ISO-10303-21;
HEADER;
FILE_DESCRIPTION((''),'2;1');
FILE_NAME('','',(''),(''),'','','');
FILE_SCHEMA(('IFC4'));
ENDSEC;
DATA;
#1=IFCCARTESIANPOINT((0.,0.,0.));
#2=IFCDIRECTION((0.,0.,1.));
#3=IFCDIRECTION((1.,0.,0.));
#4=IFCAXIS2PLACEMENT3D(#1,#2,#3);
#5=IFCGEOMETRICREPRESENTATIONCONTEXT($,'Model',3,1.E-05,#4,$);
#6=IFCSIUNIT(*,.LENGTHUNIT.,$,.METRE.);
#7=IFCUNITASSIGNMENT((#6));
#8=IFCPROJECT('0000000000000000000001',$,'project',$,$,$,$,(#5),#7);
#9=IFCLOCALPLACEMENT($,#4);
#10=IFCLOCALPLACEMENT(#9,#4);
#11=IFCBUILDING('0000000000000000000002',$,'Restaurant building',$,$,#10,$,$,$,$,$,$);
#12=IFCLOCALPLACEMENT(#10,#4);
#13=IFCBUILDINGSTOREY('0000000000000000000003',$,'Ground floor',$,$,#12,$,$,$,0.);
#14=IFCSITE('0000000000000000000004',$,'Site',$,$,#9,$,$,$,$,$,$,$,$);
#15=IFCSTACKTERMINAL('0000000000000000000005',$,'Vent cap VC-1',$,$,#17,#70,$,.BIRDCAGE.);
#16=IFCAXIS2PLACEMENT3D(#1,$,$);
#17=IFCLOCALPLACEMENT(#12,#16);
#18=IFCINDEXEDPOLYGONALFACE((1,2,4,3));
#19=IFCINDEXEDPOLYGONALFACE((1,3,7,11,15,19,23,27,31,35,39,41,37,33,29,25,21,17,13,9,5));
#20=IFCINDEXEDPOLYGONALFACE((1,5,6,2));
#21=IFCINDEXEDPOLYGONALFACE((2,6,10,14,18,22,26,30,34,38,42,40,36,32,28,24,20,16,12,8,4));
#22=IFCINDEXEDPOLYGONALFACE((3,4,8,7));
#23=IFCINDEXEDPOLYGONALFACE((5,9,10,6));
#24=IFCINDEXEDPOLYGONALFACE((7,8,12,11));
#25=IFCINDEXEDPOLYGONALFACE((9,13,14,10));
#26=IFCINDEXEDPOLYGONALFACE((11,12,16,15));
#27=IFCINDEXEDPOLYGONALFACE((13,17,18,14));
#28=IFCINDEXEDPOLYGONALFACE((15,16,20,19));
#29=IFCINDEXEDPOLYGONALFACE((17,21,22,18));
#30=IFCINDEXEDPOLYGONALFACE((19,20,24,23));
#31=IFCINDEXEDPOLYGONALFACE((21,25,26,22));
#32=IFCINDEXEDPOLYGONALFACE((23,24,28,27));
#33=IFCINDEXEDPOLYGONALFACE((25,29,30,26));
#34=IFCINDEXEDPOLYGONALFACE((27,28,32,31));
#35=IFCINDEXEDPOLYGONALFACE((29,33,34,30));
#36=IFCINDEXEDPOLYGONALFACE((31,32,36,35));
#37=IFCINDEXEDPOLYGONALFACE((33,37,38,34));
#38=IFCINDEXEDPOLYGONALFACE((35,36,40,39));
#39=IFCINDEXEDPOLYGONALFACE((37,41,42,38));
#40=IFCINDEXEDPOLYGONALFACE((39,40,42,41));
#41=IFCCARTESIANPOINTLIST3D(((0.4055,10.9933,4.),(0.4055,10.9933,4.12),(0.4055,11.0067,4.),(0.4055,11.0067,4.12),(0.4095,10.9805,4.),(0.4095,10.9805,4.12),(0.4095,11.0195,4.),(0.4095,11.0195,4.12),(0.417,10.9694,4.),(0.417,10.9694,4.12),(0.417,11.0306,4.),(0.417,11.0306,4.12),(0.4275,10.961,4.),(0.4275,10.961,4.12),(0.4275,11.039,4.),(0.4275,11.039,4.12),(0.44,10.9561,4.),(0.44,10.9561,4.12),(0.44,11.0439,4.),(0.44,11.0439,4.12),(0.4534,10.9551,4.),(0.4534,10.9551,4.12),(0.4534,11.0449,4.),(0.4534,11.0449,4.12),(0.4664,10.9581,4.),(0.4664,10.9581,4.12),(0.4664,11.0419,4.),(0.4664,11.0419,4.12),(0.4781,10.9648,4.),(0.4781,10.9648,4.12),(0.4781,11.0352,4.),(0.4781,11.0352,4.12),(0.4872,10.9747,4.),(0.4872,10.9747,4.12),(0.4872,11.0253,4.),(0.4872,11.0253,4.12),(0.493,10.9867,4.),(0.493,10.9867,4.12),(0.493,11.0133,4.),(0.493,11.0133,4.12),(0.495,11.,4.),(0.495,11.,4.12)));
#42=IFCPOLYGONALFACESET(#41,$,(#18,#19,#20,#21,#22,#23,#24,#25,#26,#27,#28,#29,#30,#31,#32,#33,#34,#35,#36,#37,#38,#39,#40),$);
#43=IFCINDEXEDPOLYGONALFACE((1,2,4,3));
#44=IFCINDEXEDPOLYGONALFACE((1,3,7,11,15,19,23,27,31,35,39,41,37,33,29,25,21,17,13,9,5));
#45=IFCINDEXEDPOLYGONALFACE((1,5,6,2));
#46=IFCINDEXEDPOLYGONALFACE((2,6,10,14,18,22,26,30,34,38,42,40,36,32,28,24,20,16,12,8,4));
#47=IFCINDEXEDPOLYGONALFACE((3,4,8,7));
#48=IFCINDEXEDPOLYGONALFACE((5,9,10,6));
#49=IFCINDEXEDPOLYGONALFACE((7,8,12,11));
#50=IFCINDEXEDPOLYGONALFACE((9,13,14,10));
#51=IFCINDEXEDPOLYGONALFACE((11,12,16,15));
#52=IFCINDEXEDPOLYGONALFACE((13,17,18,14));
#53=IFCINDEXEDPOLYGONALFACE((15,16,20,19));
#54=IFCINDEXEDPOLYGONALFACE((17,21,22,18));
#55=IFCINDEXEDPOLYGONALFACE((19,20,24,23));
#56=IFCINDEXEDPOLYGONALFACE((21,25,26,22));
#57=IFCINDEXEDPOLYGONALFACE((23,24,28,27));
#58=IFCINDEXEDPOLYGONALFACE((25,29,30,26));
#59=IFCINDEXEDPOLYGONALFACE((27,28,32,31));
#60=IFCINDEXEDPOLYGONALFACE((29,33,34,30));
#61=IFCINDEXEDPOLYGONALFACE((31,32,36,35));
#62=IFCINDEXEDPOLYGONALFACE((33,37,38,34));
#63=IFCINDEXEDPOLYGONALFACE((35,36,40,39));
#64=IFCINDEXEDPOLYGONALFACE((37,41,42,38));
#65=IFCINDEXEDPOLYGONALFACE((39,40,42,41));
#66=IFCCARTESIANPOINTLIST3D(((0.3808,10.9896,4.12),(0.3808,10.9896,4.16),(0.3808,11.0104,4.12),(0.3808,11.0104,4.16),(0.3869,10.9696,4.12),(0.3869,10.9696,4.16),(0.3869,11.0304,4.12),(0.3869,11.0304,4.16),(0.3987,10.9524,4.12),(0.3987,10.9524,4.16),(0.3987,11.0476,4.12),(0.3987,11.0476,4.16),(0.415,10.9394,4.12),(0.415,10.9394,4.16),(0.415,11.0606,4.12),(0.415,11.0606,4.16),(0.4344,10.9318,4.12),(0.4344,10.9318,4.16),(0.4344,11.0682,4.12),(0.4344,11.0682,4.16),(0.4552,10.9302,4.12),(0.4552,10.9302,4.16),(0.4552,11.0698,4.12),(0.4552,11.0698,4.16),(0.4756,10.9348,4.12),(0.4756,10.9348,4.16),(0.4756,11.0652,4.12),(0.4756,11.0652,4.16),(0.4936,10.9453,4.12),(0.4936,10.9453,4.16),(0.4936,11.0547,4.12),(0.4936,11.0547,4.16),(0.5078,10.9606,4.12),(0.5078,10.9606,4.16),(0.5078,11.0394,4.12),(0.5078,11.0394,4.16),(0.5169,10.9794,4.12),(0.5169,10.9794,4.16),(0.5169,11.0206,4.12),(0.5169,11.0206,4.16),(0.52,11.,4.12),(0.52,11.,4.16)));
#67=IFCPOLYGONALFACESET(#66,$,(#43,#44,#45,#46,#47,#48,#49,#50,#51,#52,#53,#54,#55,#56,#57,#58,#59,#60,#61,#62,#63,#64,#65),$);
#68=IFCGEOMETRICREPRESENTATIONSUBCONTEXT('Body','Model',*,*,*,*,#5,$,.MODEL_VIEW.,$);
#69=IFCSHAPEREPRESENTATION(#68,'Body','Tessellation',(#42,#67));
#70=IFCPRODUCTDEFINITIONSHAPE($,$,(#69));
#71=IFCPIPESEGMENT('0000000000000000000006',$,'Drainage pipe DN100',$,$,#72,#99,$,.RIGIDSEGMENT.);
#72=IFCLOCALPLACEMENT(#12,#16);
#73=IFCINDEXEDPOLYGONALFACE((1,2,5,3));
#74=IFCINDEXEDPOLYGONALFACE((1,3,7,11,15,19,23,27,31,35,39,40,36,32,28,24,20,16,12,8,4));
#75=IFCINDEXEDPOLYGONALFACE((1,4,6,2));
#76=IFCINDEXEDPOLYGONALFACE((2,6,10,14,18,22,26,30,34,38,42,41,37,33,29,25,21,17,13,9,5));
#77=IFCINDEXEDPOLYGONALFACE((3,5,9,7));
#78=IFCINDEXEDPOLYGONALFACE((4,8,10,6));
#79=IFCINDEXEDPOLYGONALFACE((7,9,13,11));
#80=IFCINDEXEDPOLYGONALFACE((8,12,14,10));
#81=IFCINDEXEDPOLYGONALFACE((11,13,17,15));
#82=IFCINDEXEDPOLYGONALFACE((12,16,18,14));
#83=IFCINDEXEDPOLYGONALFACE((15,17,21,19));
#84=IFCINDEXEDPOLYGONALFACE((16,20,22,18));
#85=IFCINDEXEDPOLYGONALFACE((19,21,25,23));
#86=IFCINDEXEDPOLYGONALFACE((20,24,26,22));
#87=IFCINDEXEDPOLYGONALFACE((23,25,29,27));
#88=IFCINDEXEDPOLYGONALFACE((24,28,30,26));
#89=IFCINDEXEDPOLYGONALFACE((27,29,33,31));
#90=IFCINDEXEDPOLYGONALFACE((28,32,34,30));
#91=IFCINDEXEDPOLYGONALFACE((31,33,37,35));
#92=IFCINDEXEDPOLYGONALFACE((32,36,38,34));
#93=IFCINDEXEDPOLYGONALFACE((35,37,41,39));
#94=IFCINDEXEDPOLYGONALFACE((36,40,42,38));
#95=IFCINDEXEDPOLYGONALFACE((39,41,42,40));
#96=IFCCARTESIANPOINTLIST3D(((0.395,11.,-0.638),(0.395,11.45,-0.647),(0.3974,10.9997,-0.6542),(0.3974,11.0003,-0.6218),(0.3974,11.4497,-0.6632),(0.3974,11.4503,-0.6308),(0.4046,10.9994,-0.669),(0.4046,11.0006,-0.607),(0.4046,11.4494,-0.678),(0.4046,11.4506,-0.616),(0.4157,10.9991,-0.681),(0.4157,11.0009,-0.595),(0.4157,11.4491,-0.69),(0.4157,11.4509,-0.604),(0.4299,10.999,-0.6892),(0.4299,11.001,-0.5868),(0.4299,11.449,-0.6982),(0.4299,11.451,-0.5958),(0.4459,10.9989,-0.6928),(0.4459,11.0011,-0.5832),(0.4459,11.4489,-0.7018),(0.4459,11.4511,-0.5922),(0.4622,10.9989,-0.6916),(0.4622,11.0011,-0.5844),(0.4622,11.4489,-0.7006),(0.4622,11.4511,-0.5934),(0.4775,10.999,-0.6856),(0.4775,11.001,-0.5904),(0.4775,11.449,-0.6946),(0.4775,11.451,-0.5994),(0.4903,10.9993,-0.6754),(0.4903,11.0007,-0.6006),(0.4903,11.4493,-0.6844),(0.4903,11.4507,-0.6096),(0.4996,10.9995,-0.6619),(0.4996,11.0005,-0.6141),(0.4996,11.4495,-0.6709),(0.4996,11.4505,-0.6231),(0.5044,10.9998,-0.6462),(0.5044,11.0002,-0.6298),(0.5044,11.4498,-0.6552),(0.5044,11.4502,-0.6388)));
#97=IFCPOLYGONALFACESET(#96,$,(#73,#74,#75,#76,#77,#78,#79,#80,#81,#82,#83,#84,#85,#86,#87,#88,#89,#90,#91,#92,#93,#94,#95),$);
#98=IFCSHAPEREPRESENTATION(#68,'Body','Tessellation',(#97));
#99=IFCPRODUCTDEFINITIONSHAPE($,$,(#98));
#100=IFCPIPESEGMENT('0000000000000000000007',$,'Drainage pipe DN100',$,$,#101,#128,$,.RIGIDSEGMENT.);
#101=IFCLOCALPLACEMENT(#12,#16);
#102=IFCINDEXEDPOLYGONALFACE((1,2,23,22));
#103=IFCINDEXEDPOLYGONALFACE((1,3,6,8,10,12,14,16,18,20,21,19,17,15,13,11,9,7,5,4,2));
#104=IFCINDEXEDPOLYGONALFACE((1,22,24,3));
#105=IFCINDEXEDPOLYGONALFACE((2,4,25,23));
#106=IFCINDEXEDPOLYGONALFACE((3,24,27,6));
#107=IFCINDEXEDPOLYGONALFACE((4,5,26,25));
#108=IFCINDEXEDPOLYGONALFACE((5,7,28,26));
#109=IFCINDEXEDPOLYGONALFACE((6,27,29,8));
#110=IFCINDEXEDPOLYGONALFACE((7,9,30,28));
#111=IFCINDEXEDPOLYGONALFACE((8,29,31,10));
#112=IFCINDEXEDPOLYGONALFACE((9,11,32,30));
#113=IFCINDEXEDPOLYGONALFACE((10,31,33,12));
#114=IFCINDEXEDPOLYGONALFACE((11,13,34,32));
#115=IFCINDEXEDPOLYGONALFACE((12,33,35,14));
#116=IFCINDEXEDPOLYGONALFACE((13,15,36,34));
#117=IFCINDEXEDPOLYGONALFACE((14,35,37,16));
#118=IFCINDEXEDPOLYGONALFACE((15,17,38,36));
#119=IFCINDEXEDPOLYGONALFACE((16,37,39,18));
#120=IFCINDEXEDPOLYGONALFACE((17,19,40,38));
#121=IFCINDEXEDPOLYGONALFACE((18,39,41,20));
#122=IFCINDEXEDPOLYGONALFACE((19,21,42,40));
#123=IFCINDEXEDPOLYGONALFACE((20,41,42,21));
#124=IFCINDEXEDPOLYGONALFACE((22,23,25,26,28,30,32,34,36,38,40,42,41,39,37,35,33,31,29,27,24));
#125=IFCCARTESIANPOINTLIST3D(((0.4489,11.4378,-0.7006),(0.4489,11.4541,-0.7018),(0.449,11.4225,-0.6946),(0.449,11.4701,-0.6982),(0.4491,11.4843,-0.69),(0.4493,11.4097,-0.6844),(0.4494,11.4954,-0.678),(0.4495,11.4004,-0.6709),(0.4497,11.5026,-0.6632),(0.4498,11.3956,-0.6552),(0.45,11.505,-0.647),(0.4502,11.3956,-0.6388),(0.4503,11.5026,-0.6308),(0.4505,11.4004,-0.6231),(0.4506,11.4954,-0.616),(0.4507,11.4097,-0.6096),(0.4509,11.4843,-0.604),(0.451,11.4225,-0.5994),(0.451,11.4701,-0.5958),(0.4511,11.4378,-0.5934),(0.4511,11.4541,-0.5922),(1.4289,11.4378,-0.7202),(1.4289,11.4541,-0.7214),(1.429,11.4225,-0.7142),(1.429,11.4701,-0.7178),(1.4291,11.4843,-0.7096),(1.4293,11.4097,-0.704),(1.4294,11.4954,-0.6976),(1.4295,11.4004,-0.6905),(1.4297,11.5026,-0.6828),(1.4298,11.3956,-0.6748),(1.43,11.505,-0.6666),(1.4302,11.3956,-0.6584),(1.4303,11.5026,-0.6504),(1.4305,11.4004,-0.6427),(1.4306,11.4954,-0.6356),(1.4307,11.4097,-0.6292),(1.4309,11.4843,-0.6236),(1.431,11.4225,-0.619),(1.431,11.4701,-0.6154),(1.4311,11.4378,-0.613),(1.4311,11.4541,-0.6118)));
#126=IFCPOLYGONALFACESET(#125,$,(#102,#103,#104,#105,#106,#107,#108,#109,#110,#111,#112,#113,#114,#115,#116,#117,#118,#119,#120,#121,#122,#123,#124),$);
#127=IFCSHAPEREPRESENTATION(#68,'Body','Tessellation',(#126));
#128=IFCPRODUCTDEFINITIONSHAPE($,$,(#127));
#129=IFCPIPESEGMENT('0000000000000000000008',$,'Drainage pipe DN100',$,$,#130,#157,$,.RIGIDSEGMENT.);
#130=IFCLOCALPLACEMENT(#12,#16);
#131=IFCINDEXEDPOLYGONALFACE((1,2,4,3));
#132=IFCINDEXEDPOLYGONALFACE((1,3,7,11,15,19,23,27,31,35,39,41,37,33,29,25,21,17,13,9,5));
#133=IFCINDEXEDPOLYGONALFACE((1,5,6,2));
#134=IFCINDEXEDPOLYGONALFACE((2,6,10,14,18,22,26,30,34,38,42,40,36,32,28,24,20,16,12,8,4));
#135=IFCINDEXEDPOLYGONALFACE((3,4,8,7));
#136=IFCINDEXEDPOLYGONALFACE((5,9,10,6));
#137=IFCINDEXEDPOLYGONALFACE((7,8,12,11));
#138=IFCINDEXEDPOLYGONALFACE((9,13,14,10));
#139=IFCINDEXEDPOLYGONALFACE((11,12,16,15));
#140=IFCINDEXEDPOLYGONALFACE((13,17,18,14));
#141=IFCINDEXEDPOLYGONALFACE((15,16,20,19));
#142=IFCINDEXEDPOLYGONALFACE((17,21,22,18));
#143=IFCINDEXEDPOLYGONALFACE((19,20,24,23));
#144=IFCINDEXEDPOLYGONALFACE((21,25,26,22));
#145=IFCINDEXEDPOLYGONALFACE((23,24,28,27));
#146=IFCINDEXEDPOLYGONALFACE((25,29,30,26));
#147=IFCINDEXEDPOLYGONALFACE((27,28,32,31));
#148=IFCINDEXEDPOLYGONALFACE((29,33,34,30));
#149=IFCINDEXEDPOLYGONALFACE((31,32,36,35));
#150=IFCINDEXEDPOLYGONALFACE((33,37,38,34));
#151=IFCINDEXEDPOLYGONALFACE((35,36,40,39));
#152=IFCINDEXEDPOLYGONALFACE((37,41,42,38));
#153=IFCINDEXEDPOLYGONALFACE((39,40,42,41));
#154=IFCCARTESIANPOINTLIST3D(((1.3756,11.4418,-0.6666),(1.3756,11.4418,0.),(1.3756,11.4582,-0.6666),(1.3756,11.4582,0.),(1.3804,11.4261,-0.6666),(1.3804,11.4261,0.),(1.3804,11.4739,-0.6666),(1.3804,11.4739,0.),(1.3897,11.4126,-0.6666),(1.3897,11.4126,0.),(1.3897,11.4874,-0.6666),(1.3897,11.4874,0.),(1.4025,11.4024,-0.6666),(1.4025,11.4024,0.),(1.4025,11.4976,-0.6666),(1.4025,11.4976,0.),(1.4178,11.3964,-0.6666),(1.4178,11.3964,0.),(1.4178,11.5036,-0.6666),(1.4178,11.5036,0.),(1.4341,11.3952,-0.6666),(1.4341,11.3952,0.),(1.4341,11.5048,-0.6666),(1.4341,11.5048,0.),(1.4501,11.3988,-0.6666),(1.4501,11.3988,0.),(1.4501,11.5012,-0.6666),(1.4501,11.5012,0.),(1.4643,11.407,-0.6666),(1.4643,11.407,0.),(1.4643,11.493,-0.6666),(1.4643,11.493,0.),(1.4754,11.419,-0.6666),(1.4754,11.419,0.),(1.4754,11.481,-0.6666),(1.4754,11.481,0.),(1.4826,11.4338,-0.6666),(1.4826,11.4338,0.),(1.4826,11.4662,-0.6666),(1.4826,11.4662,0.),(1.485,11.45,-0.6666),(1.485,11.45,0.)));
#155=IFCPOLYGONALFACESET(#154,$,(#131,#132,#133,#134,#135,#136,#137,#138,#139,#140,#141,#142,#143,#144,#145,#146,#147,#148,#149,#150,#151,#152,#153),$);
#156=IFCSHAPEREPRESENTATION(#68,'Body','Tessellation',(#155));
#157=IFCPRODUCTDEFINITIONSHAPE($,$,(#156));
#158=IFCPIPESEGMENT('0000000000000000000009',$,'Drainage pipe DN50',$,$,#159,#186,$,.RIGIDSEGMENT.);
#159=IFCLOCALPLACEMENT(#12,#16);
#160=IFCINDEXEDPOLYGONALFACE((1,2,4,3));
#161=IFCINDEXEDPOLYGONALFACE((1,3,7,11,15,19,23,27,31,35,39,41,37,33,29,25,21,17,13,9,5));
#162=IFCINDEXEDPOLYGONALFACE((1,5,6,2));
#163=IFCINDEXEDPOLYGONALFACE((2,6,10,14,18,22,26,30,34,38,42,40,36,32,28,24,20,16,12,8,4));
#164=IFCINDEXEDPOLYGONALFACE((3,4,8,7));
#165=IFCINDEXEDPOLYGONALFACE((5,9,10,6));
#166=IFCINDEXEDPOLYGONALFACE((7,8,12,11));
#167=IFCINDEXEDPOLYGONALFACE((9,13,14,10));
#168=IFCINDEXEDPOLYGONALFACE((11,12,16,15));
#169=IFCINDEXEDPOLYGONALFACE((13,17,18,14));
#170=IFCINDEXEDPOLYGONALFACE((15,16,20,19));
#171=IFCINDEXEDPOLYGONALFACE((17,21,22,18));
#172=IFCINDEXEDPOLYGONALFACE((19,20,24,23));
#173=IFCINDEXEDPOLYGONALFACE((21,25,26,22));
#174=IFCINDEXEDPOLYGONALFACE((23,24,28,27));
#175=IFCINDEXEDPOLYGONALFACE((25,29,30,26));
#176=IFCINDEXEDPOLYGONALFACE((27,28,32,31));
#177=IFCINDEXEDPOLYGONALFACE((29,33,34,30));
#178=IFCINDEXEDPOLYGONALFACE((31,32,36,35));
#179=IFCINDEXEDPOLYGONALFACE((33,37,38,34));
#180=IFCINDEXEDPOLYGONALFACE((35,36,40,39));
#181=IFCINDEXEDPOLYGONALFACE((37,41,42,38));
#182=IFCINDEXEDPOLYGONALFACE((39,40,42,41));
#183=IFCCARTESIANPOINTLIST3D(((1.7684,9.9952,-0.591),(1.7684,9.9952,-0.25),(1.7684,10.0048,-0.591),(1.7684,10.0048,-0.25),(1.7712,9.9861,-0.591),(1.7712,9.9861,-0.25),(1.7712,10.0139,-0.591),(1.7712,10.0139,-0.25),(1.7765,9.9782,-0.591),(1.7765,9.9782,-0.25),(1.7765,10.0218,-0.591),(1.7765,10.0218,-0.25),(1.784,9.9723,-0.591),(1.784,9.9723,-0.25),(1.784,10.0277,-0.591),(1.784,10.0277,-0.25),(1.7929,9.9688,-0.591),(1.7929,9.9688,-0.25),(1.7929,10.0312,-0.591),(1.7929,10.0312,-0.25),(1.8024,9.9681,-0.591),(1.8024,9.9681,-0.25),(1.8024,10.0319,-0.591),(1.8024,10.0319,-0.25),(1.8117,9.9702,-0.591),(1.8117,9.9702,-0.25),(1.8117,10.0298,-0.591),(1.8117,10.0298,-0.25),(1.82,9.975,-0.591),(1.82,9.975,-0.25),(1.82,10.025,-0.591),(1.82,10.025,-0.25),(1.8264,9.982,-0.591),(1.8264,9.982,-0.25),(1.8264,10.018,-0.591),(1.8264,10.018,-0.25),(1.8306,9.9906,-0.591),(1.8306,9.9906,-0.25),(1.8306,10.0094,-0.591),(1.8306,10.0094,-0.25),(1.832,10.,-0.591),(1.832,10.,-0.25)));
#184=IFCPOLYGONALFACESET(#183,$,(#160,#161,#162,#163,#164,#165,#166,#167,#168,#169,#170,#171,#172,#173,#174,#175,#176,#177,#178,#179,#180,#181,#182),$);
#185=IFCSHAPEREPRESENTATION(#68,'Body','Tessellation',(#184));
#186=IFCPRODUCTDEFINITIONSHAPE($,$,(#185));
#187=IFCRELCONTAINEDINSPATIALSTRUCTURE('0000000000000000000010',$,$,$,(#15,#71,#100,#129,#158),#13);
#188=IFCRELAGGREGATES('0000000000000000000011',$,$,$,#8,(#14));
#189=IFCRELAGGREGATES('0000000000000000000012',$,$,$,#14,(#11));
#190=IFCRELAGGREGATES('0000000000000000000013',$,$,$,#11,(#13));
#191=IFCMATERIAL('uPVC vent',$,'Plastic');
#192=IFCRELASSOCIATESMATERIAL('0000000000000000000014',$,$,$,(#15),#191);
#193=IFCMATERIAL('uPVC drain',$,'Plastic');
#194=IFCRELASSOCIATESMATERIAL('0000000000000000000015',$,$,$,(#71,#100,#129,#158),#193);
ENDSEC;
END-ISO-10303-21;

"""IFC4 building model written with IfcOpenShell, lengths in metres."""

from ifc_helpers import new_model, si_unit, frame, origin_with_axes, origin_2d, place, context, subcontext, project, spatial, circle, extrude, material, element, save


model = new_model("IFC4")

# Units and contexts
model_context = context("Model", 3, precision=1e-05, world=origin_with_axes())
body_context = subcontext(model_context, "Body", "Model", "MODEL_VIEW")
ifc_project = project(units=[si_unit("LENGTHUNIT", "METRE")], contexts=[model_context])

# Site, building, storey
site_placement = place(None, origin_with_axes())
site = spatial("IfcSite", under=ifc_project, at=site_placement, Name="Site")
building_placement = place(site_placement, origin_with_axes())
building = spatial("IfcBuilding", under=site, at=building_placement, Name="Restaurant building")
storey_placement = place(building_placement, origin_with_axes())
storey = spatial("IfcBuildingStorey", under=building, at=storey_placement, Name="Ground floor", Elevation=0.0)

# Shared definitions
ifc_material_1 = material(Name="uPVC drain", Category="Plastic")

# Stack terminal
ifc_material_2 = material(Name="uPVC vent", Category="Plastic")
stack_terminal_1_placement = place(storey_placement, frame((0.45, 11.0, 0.0)))
element("IfcStackTerminal", 1, at=stack_terminal_1_placement, inside=storey, material=ifc_material_2, Name="Vent cap VC-1", PredefinedType="BIRDCAGE", context=body_context, shape_type="SweptSolid", body=[
    extrude(circle(Radius=0.045, at=origin_2d()), frame((0.0, 0.0, 4.0)), (0.0, 0.0, 1.0), 0.12),
    extrude(circle(Radius=0.07, at=origin_2d()), frame((0.0, 0.0, 4.12)), (0.0, 0.0, 1.0), 0.04),
])

# Pipe segments
pipe_segment_1_placement = place(storey_placement, frame((0.45, 11.0, -0.638)))
element("IfcPipeSegment", 2, at=pipe_segment_1_placement, inside=storey, material=ifc_material_1, Name="Drainage pipe DN100", PredefinedType="RIGIDSEGMENT", context=body_context, shape_type="SweptSolid", body=[
    extrude(circle(Radius=0.055, at=origin_2d()), frame((0.0, 0.0, 0.0), z_axis=(0.0, 0.9998, -0.019996), x_axis=(-1.0, 0.0, 0.0)), (0.0, 0.0, 1.0), 0.4501),
])
pipe_segment_2_placement = place(storey_placement, frame((0.45, 11.45, -0.647)))
element("IfcPipeSegment", 3, at=pipe_segment_2_placement, inside=storey, material=ifc_material_1, Name="Drainage pipe DN100", PredefinedType="RIGIDSEGMENT", context=body_context, shape_type="SweptSolid", body=[
    extrude(circle(Radius=0.055, at=origin_2d()), frame((0.0, 0.0, 0.0), z_axis=(0.9998, 0.0, -0.019996), x_axis=(0.0, 1.0, 0.0)), (0.0, 0.0, 1.0), 0.9802),
])
pipe_segment_3_placement = place(storey_placement, frame((1.43, 11.45, 0.0)))
element("IfcPipeSegment", 4, at=pipe_segment_3_placement, inside=storey, material=ifc_material_1, Name="Drainage pipe DN100", PredefinedType="RIGIDSEGMENT", context=body_context, shape_type="SweptSolid", body=[
    extrude(circle(Radius=0.055, at=origin_2d()), frame((0.0, 0.0, 0.0), z_axis=(0.0, 0.0, -1.0), x_axis=(1.0, 0.0, 0.0)), (0.0, 0.0, 1.0), 0.6666),
])
pipe_segment_4_placement = place(storey_placement, frame((1.8, 10.0, -0.25)))
element("IfcPipeSegment", 5, at=pipe_segment_4_placement, inside=storey, material=ifc_material_1, Name="Drainage pipe DN50", PredefinedType="RIGIDSEGMENT", context=body_context, shape_type="SweptSolid", body=[
    extrude(circle(Radius=0.032, at=origin_2d()), frame((0.0, 0.0, 0.0), z_axis=(0.0, 0.0, -1.0), x_axis=(1.0, 0.0, 0.0)), (0.0, 0.0, 1.0), 0.341),
])

save(model, "model.ifc")
